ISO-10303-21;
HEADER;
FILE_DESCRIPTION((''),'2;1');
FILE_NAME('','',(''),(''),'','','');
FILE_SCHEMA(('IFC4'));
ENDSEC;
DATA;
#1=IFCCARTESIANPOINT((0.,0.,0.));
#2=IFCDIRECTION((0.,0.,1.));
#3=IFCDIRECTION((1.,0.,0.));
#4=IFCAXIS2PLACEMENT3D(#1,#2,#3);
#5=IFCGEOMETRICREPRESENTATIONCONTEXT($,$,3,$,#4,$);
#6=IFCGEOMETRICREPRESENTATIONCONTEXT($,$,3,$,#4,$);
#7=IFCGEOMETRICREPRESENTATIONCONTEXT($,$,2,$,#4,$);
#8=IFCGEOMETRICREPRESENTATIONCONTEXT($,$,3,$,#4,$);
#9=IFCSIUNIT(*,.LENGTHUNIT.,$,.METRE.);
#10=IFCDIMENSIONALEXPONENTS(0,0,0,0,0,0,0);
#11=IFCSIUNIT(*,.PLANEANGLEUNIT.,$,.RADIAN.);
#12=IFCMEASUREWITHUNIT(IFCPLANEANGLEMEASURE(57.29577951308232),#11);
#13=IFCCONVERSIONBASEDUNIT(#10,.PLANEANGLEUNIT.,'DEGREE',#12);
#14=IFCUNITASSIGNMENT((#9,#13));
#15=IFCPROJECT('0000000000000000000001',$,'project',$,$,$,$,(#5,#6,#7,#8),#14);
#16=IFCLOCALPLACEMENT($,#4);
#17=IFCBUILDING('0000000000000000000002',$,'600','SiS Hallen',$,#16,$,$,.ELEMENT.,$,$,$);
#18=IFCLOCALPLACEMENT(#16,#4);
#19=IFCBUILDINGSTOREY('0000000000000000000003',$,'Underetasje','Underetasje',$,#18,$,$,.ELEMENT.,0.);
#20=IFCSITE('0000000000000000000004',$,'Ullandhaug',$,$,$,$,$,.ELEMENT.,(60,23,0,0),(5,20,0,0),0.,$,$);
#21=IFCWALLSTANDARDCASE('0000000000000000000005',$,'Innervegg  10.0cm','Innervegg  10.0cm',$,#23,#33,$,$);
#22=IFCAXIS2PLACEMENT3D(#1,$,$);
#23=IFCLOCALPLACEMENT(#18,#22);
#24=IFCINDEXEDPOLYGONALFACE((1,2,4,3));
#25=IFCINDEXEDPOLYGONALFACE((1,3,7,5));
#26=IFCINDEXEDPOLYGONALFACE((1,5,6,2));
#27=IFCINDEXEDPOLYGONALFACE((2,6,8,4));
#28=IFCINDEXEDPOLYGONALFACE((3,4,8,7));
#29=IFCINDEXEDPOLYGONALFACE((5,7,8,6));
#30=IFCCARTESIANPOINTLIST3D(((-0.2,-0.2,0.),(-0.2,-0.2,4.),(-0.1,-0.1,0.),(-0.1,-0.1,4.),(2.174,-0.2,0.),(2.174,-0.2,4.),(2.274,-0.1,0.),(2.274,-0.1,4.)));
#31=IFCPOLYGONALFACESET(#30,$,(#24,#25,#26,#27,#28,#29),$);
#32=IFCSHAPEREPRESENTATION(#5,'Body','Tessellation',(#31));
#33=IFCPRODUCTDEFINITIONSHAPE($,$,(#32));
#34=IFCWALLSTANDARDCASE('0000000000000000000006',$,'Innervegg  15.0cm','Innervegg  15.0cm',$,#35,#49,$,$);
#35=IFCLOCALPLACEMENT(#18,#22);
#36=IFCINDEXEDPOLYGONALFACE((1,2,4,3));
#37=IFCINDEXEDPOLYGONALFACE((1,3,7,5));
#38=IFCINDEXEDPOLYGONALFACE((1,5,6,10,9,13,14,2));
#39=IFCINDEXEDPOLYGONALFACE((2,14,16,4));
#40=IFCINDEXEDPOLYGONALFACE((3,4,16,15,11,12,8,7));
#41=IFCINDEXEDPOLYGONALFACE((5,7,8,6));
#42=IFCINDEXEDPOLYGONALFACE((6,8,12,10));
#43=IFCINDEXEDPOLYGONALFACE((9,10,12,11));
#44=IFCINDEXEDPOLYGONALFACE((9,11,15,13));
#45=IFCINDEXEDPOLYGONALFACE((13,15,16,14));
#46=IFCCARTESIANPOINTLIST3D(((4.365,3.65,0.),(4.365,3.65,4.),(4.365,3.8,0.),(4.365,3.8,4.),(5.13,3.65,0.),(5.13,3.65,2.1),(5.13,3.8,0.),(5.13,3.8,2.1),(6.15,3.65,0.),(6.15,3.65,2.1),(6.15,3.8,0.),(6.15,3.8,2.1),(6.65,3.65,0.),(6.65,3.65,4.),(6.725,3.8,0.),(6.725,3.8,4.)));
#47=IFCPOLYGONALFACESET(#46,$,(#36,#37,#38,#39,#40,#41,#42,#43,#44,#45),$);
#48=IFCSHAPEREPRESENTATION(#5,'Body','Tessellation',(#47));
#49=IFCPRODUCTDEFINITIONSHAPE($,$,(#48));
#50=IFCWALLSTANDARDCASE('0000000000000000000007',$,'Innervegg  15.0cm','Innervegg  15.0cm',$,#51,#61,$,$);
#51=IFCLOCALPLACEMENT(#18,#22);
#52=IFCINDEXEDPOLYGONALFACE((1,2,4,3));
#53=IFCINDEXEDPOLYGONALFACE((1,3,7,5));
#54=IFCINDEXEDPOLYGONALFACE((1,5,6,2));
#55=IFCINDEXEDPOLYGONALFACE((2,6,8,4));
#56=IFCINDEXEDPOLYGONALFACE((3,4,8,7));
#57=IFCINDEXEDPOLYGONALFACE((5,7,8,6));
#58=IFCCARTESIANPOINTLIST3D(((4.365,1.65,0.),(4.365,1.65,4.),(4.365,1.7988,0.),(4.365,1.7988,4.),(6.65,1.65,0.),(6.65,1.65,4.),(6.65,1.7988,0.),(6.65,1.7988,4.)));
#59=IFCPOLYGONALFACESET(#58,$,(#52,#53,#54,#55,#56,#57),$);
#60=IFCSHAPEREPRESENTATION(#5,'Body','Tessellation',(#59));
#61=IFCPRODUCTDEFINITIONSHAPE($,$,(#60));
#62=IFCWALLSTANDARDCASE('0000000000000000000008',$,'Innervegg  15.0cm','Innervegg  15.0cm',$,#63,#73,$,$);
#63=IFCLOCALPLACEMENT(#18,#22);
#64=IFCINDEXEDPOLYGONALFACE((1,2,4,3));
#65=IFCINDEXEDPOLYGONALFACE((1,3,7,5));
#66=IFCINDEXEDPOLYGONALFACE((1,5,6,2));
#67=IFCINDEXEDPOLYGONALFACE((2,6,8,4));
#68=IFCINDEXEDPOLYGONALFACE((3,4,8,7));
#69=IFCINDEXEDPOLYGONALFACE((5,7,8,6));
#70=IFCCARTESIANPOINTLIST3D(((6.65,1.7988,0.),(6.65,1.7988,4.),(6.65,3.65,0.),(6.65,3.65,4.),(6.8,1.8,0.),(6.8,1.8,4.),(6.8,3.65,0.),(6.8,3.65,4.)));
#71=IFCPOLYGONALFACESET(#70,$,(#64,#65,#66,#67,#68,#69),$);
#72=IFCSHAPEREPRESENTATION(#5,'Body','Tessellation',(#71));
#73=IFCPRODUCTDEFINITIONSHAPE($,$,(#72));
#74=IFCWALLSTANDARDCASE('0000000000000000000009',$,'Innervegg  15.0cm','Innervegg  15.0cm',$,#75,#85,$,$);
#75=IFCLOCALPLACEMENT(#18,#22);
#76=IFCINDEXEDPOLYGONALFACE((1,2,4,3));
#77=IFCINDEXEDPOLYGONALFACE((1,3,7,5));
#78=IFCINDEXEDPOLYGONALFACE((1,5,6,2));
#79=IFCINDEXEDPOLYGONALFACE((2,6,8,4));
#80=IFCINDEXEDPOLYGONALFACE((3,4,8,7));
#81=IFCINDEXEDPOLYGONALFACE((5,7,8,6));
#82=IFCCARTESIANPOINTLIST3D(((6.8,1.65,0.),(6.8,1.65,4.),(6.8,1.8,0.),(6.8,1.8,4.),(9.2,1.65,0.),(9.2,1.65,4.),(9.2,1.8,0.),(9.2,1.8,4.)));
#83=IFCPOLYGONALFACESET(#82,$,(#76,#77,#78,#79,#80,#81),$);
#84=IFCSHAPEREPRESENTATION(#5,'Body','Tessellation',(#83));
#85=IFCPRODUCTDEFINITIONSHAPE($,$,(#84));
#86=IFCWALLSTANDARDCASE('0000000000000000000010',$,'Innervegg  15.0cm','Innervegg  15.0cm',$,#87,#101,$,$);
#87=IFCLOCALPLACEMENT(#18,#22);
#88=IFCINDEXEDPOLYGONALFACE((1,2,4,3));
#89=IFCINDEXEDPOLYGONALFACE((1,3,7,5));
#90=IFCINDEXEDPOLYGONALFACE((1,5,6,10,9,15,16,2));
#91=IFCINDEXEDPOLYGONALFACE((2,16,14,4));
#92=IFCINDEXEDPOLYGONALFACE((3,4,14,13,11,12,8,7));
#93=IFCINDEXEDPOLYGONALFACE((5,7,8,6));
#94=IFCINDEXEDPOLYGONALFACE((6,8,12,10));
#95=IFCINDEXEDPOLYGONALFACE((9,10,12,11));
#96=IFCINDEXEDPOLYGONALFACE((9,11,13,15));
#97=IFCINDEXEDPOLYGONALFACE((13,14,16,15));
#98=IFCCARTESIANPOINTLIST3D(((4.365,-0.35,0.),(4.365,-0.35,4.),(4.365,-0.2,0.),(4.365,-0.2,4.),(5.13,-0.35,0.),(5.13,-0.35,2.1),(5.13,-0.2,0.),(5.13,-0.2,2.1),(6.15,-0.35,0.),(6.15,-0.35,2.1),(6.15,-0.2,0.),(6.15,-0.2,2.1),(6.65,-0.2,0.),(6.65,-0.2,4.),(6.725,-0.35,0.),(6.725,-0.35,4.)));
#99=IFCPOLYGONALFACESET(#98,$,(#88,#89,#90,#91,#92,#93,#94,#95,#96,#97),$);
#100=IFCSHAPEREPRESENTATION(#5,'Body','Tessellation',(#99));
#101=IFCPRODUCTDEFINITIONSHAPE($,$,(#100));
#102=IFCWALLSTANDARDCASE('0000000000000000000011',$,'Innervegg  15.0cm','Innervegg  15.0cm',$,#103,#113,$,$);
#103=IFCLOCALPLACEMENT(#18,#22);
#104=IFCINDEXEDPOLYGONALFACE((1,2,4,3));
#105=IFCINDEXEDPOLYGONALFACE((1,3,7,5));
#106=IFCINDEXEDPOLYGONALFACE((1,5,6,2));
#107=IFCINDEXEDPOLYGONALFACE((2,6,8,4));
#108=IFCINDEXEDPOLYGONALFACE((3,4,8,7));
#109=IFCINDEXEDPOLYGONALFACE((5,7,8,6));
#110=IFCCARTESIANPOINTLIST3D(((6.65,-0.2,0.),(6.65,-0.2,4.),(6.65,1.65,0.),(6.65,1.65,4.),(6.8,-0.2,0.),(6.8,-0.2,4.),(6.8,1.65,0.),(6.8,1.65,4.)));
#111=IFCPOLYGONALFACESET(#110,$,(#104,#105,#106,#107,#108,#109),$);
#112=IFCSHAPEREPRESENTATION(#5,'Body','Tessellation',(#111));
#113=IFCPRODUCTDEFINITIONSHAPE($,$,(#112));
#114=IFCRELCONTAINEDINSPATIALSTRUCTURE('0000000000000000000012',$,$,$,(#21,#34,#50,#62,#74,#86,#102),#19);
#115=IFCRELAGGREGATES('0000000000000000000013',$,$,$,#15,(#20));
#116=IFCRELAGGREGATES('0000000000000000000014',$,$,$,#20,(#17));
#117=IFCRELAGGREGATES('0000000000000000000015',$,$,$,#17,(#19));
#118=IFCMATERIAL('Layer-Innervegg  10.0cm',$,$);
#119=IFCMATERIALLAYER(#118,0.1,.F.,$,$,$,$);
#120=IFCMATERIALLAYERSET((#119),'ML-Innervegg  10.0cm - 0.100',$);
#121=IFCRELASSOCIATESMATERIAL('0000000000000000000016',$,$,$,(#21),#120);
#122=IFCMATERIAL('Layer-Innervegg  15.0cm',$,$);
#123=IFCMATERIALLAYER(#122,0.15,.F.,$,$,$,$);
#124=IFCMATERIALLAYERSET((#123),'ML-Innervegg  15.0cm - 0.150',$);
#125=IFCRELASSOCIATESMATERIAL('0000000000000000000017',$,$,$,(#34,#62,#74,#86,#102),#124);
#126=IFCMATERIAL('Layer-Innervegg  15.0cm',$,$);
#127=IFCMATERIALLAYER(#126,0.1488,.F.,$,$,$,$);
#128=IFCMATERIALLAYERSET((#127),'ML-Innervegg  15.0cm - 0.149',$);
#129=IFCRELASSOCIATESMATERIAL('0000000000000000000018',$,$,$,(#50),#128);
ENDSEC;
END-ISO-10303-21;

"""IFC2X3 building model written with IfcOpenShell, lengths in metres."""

from ifc_helpers import new_model, entity, si_unit, converted_unit, frame, origin_with_axes, place, context, project, spatial, polyline, outline, extrude, material, layer, layer_set, layer_usage, element, save


model = new_model("IFC2X3")

# Units and contexts
context_of_model_1 = context(None, 3, world=origin_with_axes())
context_of_model_2 = context(None, 3, world=origin_with_axes())
context_of_model_3 = context(None, 2, world=origin_with_axes())
context_of_model_4 = context(None, 3, world=origin_with_axes())
ifc_project = project(units=[si_unit("LENGTHUNIT", "METRE"), converted_unit("PLANEANGLEUNIT", "DEGREE", entity("IfcPlaneAngleMeasure", 57.29577951308232), si_unit("PLANEANGLEUNIT", "RADIAN"), dimensions=[0, 0, 0, 0, 0, 0, 0])], contexts=[context_of_model_1, context_of_model_2, context_of_model_3, context_of_model_4])

# Site, building, storey
site = spatial("IfcSite", under=ifc_project, Name="Ullandhaug", CompositionType="ELEMENT", RefLatitude=(60, 23, 0, 0), RefLongitude=(5, 20, 0, 0), RefElevation=0.0)
building_placement = place(None, origin_with_axes())
building = spatial("IfcBuilding", under=site, at=building_placement, Name="600", Description="SiS Hallen", CompositionType="ELEMENT")
storey_placement = place(building_placement, origin_with_axes())
storey = spatial("IfcBuildingStorey", under=building, at=storey_placement, Name="Underetasje", Description="Underetasje", CompositionType="ELEMENT", Elevation=0.0)

# Shared definitions
ifc_material_1 = material(Name="Layer-Innervegg  10.0cm")
ifc_layer_1 = layer(ifc_material_1, 0.1, ventilated=False)
ifc_layer_set_1 = layer_set([ifc_layer_1], Name="ML-Innervegg  10.0cm - 0.100")
ifc_layer_usage_1 = layer_usage(ifc_layer_set_1, "AXIS2", "POSITIVE", 0.0)

# Wall
wall_1_placement = place(storey_placement, frame((2.274, -0.1, 0.0), z_axis=(0.0, 0.0, 1.0), x_axis=(-1.0, 0.0, 0.0)))
element("IfcWallStandardCase", 1, at=wall_1_placement, inside=storey, material=ifc_layer_usage_1, Name="Innervegg  10.0cm", Description="Innervegg  10.0cm", context=context_of_model_1, shape_type="SweptSolid", body=[
    extrude(outline(polyline([(0.0, 0.0), (2.374, 0.0), (2.474, 0.1), (0.1, 0.1), (0.0, 0.0)])), frame((0.0, 0.0, 0.0), z_axis=(0.0, 0.0, 1.0), x_axis=(1.0, 0.0, 0.0)), (0.0, 0.0, 1.0), 4.0),
])

# Wall, opening
ifc_material_2 = material(Name="Layer-Innervegg  15.0cm")
ifc_layer_2 = layer(ifc_material_2, 0.15, ventilated=False)
ifc_layer_set_2 = layer_set([ifc_layer_2], Name="ML-Innervegg  15.0cm - 0.150")
ifc_layer_usage_2 = layer_usage(ifc_layer_set_2, "AXIS2", "POSITIVE", 0.0)
wall_2_placement = place(storey_placement, frame((4.365, 3.65, 0.0), z_axis=(0.0, 0.0, 1.0), x_axis=(1.0, 0.0, 0.0)))
wall_2 = element("IfcWallStandardCase", 2, at=wall_2_placement, inside=storey, material=ifc_layer_usage_2, Name="Innervegg  15.0cm", Description="Innervegg  15.0cm", context=context_of_model_1, shape_type="SweptSolid", body=[
    extrude(outline(polyline([(0.0, 0.0), (2.285, 0.0), (2.36, 0.15), (0.0, 0.15), (0.0, 0.0)])), origin_with_axes(), (0.0, 0.0, 1.0), 4.0),
])
opening_1_placement = place(wall_2_placement, frame((0.765, 0.15, 0.0), z_axis=(0.0, 0.0, 1.0), x_axis=(1.0, 0.0, 0.0)))
element("IfcOpeningElement", 3, at=opening_1_placement, cuts=wall_2, context=context_of_model_1, shape_type="SweptSolid", body=[
    extrude(outline(polyline([(0.0, 0.0), (2.1, 0.0), (2.1, 1.02), (0.0, 1.02), (0.0, 0.0)])), frame((0.0, 0.0, 0.0), z_axis=(0.0, 1.0, 0.0), x_axis=(0.0, 0.0, 1.0)), (0.0, 0.0, -1.0), 0.15),
])

# Walls
ifc_material_3 = material(Name="Layer-Innervegg  15.0cm")
ifc_layer_3 = layer(ifc_material_3, 0.1488, ventilated=False)
ifc_layer_set_3 = layer_set([ifc_layer_3], Name="ML-Innervegg  15.0cm - 0.149")
ifc_layer_usage_3 = layer_usage(ifc_layer_set_3, "AXIS2", "POSITIVE", 0.0)
wall_3_placement = place(storey_placement, frame((4.365, 1.65, 0.0), z_axis=(0.0, 0.0, 1.0), x_axis=(1.0, 0.0, 0.0)))
element("IfcWallStandardCase", 4, at=wall_3_placement, inside=storey, material=ifc_layer_usage_3, Name="Innervegg  15.0cm", Description="Innervegg  15.0cm", context=context_of_model_1, shape_type="SweptSolid", body=[
    extrude(outline(polyline([(0.0, 0.0), (2.285, 0.0), (2.285, 0.1488), (0.0, 0.1488), (0.0, 0.0)])), origin_with_axes(), (0.0, 0.0, 1.0), 4.0),
])
wall_4_placement = place(storey_placement, frame((6.8, 1.8, 0.0), z_axis=(0.0, 0.0, 1.0), x_axis=(0.0, 1.0, 0.0)))
element("IfcWallStandardCase", 5, at=wall_4_placement, inside=storey, material=ifc_layer_usage_2, Name="Innervegg  15.0cm", Description="Innervegg  15.0cm", context=context_of_model_1, shape_type="SweptSolid", body=[
    extrude(outline(polyline([(0.0, 0.0), (1.85, 0.0), (1.85, 0.15), (-0.0012, 0.15), (0.0, 0.0)])), frame((0.0, 0.0, 0.0), z_axis=(0.0, 0.0, 1.0), x_axis=(1.0, 0.0, 0.0)), (0.0, 0.0, 1.0), 4.0),
])
wall_5_placement = place(storey_placement, frame((6.8, 1.65, 0.0), z_axis=(0.0, 0.0, 1.0), x_axis=(1.0, 0.0, 0.0)))
element("IfcWallStandardCase", 6, at=wall_5_placement, inside=storey, material=ifc_layer_usage_2, Name="Innervegg  15.0cm", Description="Innervegg  15.0cm", context=context_of_model_1, shape_type="SweptSolid", body=[
    extrude(outline(polyline([(0.0, 0.0), (2.4, 0.0), (2.4, 0.15), (0.0, 0.15), (0.0, 0.0)])), origin_with_axes(), (0.0, 0.0, 1.0), 4.0),
])

# Wall, opening
wall_6_placement = place(storey_placement, frame((6.65, -0.2, 0.0), z_axis=(0.0, 0.0, 1.0), x_axis=(-1.0, 0.0, 0.0)))
wall_6 = element("IfcWallStandardCase", 7, at=wall_6_placement, inside=storey, material=ifc_layer_usage_2, Name="Innervegg  15.0cm", Description="Innervegg  15.0cm", context=context_of_model_1, shape_type="SweptSolid", body=[
    extrude(outline(polyline([(0.0, 0.0), (2.285, 0.0), (2.285, 0.15), (-0.075, 0.15), (0.0, 0.0)])), frame((0.0, 0.0, 0.0), z_axis=(0.0, 0.0, 1.0), x_axis=(1.0, 0.0, 0.0)), (0.0, 0.0, 1.0), 4.0),
])
opening_2_placement = place(wall_6_placement, frame((0.5, 0.15, 0.0), z_axis=(0.0, 0.0, 1.0), x_axis=(1.0, 0.0, 0.0)))
element("IfcOpeningElement", 8, at=opening_2_placement, cuts=wall_6, context=context_of_model_1, shape_type="SweptSolid", body=[
    extrude(outline(polyline([(0.0, 0.0), (2.1, 0.0), (2.1, 1.02), (0.0, 1.02), (0.0, 0.0)])), frame((0.0, 0.0, 0.0), z_axis=(0.0, 1.0, 0.0), x_axis=(0.0, 0.0, 1.0)), (0.0, 0.0, -1.0), 0.15),
])

# Wall
wall_7_placement = place(storey_placement, frame((6.8, -0.2, 0.0), z_axis=(0.0, 0.0, 1.0), x_axis=(0.0, 1.0, 0.0)))
element("IfcWallStandardCase", 9, at=wall_7_placement, inside=storey, material=ifc_layer_usage_2, Name="Innervegg  15.0cm", Description="Innervegg  15.0cm", context=context_of_model_1, shape_type="SweptSolid", body=[
    extrude(outline(polyline([(0.0, 0.0), (1.85, 0.0), (1.85, 0.15), (0.0, 0.15), (0.0, 0.0)])), frame((0.0, 0.0, 0.0), z_axis=(0.0, 0.0, 1.0), x_axis=(1.0, 0.0, 0.0)), (0.0, 0.0, 1.0), 4.0),
])

save(model, "model.ifc")
